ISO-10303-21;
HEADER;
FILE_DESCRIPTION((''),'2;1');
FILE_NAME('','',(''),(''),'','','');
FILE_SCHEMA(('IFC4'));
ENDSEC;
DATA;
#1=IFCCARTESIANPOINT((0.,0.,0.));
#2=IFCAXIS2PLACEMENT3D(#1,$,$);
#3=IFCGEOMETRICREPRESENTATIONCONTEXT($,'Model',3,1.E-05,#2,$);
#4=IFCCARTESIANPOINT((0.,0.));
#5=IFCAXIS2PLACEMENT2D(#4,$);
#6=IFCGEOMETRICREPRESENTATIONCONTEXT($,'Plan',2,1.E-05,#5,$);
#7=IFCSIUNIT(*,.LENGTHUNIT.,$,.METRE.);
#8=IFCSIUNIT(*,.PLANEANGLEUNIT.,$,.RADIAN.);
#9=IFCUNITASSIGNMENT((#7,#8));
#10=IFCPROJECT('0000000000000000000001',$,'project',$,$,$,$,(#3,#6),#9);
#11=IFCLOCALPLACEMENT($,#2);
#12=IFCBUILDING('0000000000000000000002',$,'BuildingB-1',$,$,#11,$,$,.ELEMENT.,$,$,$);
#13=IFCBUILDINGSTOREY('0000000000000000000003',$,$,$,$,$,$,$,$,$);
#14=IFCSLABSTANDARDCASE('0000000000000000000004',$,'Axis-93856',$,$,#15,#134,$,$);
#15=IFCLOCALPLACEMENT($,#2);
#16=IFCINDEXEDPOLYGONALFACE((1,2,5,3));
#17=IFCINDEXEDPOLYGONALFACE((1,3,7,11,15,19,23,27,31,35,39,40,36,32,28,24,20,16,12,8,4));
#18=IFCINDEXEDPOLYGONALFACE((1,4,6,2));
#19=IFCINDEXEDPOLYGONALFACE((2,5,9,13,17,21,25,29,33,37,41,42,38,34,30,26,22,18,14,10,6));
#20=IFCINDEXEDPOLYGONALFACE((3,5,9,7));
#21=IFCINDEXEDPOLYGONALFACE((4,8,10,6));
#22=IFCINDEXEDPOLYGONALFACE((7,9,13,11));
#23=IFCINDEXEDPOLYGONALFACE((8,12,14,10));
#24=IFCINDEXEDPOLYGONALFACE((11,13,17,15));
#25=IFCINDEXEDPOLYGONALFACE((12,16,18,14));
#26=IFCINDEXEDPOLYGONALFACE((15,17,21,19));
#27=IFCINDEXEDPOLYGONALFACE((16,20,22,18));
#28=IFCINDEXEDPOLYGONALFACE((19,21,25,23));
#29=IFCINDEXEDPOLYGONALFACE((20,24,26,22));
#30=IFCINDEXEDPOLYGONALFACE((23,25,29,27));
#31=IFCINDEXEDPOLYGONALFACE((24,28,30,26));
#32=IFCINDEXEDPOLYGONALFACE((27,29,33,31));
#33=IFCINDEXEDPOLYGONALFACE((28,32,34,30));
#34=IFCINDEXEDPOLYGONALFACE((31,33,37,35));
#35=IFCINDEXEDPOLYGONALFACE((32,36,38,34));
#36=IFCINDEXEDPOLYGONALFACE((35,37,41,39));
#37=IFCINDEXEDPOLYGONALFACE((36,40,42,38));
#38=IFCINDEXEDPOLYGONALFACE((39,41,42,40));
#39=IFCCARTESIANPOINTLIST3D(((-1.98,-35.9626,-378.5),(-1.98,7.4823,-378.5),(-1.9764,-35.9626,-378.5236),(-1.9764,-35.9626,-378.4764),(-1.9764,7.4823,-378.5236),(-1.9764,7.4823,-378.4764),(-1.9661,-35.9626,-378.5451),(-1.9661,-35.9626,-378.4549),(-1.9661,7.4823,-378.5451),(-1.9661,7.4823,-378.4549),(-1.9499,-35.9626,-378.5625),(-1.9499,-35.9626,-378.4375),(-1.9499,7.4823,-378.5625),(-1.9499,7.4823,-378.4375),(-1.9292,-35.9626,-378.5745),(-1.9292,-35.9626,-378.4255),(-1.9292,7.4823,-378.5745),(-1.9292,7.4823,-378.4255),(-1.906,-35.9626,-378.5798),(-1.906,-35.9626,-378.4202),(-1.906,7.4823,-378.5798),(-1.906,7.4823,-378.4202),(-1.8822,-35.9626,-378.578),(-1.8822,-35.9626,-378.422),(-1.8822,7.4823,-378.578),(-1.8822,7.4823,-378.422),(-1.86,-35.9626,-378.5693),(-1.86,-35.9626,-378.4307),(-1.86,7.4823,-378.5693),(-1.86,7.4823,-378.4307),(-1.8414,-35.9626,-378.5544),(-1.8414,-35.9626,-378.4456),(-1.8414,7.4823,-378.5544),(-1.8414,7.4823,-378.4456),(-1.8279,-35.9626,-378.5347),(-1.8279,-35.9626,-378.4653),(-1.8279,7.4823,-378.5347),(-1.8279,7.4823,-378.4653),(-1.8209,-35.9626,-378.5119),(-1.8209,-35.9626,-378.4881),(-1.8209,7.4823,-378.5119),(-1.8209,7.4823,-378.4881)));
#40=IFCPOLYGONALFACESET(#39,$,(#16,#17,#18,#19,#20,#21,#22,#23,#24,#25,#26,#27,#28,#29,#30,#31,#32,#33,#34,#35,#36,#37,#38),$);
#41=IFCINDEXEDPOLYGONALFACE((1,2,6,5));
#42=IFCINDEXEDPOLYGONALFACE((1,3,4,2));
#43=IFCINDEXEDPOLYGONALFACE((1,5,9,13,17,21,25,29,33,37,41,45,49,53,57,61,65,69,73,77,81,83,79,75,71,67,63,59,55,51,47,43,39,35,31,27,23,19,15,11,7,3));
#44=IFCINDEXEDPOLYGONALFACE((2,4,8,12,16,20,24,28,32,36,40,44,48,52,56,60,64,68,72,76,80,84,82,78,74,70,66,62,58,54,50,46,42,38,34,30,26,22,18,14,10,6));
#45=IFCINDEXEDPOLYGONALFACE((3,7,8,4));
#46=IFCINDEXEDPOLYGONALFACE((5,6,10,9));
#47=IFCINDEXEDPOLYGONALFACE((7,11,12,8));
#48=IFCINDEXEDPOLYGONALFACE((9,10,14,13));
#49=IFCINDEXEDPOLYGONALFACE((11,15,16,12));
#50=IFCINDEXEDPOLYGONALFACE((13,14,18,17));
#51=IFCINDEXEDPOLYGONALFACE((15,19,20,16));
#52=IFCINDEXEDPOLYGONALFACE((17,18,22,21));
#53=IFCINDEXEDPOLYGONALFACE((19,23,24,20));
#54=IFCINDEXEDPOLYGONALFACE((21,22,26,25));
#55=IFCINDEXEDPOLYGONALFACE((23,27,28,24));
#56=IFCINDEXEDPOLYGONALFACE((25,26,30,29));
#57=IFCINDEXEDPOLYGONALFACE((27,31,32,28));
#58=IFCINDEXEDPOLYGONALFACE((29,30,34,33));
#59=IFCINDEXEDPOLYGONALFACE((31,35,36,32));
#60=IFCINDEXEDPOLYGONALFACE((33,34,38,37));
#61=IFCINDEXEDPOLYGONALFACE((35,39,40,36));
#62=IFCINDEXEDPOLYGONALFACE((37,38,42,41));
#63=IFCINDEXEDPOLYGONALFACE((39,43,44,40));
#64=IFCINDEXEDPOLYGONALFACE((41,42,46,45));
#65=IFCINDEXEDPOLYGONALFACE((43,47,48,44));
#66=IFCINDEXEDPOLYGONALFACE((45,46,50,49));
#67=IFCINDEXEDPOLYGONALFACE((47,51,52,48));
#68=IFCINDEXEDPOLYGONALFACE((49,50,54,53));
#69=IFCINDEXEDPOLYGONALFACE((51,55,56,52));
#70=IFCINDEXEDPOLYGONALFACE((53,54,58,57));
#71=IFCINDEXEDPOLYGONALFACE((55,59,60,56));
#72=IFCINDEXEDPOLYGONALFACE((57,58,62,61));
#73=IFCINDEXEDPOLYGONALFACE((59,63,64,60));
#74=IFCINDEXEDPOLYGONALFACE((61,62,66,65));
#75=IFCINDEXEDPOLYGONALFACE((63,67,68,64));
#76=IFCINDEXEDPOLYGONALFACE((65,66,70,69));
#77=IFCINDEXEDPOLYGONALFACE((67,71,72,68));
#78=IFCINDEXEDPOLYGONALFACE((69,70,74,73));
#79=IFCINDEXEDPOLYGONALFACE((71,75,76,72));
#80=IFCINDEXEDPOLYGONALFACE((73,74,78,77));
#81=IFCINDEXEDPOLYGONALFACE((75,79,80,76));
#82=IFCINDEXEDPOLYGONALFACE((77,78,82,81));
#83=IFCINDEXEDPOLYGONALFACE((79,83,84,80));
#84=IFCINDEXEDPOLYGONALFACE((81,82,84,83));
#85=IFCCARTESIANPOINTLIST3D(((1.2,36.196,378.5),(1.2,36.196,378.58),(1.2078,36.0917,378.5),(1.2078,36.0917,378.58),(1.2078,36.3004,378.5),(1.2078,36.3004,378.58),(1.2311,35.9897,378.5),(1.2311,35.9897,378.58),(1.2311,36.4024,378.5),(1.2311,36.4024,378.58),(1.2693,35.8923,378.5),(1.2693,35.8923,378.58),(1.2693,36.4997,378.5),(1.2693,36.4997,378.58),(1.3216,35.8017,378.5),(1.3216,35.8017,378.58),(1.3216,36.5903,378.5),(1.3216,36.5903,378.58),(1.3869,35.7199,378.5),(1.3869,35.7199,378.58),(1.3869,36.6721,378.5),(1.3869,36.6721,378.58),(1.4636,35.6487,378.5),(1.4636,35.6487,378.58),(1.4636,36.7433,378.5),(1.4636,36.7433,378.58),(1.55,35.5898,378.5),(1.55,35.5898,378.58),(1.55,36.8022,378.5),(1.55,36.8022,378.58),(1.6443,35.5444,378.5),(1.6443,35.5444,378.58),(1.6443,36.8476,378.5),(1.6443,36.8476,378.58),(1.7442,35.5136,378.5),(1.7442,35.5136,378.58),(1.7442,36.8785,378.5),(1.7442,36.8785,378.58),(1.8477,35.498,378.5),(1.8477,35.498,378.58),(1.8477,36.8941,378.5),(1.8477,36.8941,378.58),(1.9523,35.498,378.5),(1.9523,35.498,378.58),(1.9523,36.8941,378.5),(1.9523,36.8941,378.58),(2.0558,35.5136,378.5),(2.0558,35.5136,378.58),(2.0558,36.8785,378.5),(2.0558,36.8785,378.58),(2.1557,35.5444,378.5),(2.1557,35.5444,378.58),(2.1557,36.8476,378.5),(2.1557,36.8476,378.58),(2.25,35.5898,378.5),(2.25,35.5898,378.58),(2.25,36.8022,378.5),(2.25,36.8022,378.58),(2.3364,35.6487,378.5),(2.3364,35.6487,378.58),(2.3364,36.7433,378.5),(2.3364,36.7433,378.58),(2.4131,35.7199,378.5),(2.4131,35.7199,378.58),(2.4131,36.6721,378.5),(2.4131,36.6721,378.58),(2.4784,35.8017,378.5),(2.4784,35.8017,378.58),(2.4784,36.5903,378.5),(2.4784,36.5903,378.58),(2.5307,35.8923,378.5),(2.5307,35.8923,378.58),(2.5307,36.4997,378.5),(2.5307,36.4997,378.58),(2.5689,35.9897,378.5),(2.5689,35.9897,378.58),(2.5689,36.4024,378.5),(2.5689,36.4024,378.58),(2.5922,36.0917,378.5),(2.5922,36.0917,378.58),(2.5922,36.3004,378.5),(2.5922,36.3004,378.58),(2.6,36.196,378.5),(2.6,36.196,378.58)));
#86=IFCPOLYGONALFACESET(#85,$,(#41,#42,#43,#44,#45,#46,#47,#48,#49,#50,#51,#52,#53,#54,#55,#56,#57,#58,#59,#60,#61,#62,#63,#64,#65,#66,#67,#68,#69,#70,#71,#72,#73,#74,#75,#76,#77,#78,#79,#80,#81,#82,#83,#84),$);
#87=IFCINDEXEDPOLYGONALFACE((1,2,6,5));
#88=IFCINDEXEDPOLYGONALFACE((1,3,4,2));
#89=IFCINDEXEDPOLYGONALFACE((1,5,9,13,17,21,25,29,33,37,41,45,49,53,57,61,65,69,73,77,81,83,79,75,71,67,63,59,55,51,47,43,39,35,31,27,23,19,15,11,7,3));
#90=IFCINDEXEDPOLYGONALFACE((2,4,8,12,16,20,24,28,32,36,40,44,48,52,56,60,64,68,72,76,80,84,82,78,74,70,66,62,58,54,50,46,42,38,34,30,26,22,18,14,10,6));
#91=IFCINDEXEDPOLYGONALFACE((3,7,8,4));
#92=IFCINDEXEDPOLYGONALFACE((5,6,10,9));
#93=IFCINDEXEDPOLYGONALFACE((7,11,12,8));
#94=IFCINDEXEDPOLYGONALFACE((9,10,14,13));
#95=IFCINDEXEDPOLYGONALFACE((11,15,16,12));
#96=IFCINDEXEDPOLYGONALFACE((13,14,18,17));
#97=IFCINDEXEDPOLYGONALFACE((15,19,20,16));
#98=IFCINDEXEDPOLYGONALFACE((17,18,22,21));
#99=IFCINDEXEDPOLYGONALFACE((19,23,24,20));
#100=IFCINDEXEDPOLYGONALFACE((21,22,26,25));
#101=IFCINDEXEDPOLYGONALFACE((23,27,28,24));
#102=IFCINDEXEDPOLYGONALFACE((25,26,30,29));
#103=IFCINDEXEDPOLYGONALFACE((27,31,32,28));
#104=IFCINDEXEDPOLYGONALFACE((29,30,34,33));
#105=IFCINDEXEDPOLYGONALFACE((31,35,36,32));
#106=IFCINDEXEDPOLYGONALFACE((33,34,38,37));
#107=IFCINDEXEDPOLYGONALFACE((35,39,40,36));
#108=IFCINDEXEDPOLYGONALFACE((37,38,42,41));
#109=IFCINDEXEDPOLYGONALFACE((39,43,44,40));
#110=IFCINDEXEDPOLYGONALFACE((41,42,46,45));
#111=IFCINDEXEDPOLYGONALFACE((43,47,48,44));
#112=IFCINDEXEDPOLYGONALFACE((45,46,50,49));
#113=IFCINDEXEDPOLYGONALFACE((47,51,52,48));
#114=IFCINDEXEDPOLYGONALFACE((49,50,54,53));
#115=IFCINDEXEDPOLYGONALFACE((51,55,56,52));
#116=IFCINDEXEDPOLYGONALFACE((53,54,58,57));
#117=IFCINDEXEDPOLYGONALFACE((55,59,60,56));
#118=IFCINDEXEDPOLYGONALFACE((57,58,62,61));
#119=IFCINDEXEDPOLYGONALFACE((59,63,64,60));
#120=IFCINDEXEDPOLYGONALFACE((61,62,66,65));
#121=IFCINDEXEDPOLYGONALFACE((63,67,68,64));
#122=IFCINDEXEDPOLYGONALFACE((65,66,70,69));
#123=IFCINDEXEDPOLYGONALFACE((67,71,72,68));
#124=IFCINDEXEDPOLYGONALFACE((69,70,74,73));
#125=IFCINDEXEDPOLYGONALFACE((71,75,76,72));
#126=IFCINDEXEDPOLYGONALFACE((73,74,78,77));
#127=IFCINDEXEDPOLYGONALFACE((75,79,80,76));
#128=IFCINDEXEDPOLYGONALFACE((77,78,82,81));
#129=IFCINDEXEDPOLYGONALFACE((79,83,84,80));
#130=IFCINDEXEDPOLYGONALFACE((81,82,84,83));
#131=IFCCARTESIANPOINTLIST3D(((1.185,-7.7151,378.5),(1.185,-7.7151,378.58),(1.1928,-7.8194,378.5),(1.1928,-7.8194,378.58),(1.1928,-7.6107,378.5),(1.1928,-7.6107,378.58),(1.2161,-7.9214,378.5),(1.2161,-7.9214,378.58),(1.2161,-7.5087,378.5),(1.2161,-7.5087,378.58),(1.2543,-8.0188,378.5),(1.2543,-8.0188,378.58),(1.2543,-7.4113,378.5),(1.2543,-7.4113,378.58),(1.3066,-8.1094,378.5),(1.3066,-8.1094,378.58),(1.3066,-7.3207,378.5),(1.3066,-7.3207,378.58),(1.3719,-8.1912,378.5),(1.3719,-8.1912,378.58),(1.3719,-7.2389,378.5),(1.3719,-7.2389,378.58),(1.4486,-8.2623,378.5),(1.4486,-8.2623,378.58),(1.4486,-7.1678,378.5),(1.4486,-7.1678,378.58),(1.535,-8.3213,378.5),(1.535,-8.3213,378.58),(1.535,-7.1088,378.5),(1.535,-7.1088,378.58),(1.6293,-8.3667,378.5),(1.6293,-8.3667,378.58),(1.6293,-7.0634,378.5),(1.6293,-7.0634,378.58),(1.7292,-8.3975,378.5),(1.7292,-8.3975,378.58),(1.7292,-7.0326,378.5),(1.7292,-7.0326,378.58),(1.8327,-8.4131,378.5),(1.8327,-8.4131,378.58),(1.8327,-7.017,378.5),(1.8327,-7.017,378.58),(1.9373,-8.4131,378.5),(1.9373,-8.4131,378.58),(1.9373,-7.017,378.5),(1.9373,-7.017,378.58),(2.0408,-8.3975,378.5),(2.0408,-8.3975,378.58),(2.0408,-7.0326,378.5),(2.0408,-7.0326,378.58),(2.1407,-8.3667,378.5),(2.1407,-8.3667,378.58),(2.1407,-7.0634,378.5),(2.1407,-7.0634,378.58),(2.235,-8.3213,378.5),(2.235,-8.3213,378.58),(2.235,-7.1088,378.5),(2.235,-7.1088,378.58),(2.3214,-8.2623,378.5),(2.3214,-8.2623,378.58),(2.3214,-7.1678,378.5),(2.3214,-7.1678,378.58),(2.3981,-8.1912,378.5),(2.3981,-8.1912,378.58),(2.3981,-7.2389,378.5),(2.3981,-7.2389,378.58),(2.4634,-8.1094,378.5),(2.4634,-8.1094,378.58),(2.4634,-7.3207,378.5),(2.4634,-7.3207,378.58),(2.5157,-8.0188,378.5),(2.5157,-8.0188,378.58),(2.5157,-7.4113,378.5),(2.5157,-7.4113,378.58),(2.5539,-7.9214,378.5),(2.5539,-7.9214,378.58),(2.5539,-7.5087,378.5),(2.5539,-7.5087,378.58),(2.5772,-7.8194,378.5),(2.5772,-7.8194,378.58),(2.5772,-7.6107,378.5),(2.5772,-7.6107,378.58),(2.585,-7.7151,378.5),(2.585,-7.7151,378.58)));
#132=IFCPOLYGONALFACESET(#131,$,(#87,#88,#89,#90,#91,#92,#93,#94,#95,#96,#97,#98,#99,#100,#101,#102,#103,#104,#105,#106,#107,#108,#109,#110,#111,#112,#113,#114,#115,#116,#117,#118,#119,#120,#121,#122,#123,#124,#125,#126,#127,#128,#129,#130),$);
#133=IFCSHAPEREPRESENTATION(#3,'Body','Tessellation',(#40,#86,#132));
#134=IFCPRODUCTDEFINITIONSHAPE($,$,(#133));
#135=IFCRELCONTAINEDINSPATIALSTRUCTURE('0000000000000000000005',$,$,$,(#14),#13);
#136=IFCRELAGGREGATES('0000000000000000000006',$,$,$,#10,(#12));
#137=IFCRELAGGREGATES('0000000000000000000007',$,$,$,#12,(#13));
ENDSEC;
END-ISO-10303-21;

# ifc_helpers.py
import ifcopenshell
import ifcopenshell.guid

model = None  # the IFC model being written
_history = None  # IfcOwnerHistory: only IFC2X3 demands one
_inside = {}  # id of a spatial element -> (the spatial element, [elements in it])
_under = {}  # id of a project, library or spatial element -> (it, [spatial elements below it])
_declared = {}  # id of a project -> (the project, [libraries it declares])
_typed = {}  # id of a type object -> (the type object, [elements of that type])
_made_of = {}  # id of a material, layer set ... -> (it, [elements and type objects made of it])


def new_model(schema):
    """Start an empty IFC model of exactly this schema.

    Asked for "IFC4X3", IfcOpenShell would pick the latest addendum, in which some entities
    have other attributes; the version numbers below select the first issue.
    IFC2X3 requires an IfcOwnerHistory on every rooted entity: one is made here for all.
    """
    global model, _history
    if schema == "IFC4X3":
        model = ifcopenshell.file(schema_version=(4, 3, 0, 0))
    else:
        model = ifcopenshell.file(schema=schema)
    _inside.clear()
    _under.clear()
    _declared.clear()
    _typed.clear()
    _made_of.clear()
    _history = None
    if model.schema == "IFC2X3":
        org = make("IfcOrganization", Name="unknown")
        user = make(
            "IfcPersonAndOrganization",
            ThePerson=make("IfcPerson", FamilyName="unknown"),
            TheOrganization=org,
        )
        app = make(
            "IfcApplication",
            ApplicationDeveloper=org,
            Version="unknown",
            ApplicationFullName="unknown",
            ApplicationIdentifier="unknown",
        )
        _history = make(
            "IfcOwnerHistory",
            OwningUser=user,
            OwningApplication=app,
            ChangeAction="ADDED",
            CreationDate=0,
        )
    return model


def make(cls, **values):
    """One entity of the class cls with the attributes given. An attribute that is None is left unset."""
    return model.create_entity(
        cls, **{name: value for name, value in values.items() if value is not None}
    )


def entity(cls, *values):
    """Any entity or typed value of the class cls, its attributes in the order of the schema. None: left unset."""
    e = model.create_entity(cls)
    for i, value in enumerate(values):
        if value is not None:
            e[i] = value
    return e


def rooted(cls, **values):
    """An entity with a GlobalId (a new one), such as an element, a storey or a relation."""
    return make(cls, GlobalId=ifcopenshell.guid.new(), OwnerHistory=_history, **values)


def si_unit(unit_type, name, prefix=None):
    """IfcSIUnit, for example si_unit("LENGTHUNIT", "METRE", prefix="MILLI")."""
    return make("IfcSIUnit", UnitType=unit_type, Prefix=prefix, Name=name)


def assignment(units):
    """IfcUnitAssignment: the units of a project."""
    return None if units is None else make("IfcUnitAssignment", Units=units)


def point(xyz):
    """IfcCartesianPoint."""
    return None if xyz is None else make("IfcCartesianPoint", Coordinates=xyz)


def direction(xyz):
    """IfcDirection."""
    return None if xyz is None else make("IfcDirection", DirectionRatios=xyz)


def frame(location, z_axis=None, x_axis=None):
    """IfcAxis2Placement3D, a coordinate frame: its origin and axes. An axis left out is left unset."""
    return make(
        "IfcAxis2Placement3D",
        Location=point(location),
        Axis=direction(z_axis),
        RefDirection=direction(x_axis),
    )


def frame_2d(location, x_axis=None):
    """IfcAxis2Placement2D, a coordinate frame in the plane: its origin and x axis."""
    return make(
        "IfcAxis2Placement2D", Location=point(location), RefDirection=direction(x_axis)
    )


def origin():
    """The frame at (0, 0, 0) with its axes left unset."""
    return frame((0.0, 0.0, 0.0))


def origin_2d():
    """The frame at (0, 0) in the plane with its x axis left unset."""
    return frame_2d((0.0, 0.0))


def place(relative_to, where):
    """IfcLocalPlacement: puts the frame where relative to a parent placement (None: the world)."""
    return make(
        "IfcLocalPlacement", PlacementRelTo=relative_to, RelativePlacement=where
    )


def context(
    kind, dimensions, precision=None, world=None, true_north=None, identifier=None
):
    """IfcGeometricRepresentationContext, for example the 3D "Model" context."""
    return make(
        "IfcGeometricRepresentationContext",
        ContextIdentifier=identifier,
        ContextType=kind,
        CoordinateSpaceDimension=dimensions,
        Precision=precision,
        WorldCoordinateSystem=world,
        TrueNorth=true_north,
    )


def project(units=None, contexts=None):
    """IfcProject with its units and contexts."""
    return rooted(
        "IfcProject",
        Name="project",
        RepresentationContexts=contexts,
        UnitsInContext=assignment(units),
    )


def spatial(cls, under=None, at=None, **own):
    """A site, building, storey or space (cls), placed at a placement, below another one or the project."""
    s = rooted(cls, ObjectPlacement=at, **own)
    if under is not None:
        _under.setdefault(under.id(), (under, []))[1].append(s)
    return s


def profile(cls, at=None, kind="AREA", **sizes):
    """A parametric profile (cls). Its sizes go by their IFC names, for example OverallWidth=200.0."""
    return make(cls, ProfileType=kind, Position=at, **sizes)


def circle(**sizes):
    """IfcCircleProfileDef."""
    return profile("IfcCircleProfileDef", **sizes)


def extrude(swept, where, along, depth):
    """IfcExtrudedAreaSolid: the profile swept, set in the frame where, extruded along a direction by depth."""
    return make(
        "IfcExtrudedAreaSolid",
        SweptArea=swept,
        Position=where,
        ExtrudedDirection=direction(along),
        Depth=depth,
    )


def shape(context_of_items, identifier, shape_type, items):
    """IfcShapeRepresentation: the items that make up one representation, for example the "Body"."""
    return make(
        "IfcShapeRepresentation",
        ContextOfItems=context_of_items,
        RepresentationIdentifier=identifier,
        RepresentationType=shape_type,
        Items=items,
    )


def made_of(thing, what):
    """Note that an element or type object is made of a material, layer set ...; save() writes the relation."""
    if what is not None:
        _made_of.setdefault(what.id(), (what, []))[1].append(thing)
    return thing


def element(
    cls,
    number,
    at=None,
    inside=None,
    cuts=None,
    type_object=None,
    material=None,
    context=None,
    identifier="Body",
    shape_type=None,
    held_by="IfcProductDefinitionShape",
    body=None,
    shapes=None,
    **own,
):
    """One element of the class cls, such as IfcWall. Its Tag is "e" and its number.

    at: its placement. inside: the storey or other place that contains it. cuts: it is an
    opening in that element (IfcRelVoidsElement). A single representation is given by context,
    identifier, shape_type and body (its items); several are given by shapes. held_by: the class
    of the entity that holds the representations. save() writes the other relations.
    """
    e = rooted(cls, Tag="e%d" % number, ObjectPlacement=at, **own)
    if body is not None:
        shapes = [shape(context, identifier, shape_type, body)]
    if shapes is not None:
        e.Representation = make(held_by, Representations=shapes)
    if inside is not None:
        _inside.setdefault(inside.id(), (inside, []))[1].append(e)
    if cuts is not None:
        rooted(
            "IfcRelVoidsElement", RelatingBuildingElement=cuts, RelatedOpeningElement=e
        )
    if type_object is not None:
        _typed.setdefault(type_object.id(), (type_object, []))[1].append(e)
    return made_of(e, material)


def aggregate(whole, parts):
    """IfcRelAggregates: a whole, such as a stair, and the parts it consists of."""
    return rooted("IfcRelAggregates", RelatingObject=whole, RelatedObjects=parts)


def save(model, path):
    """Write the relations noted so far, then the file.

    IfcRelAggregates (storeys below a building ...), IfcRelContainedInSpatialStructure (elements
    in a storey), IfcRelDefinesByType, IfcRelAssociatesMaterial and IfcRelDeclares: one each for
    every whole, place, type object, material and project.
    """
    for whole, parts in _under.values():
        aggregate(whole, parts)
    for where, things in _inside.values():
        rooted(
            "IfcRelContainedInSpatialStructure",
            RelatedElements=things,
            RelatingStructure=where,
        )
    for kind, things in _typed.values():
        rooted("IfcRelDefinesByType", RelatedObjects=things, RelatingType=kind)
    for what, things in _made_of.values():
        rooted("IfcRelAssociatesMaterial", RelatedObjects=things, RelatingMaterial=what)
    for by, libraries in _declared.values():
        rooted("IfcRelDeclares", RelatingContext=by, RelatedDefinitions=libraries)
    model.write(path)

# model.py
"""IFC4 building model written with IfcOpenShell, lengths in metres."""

from ifc_helpers import new_model, entity, si_unit, frame, origin, origin_2d, place, context, project, spatial, circle, extrude, element, save


model = new_model("IFC4")

# Units and contexts
model_context = context("Model", 3, precision=1e-05, world=origin())
plan_context = context("Plan", 2, precision=1e-05, world=origin_2d())
ifc_project = project(units=[si_unit("LENGTHUNIT", "METRE"), si_unit("PLANEANGLEUNIT", "RADIAN")], contexts=[model_context, plan_context])

# Building, storey
building_placement = place(None, origin())
building = spatial("IfcBuilding", under=ifc_project, at=building_placement, Name="BuildingB-1", CompositionType="ELEMENT")
storey = spatial("IfcBuildingStorey", under=building)

# Slab
element("IfcSlabStandardCase", 1, inside=storey, Name="Axis-93856", context=model_context, shape_type="AdvancedSweptSolid", body=[
    entity("IfcSurfaceCurveSweptAreaSolid", entity("IfcCircleProfileDef", "AREA", None, None, 0.08), None, entity("IfcPolyline", [entity("IfcCartesianPoint", [1.9, 35.9626, 378.5]), entity("IfcCartesianPoint", [1.9, -7.4823, 378.5])]), None, None, entity("IfcPlane", entity("IfcAxis2Placement3D", entity("IfcCartesianPoint", [1.9, 35.9626, 378.5]), entity("IfcDirection", [0.0, 0.0, 1.0]), entity("IfcDirection", [1.0, 0.0, 0.0])))),
    extrude(circle(Radius=0.7), frame((1.9, 36.196, 378.5)), (0.0, 0.0, 1.0), 0.08),
    extrude(circle(Radius=0.7), frame((1.885, -7.7151, 378.5)), (0.0, 0.0, 1.0), 0.08),
])

save(model, "model.ifc")
